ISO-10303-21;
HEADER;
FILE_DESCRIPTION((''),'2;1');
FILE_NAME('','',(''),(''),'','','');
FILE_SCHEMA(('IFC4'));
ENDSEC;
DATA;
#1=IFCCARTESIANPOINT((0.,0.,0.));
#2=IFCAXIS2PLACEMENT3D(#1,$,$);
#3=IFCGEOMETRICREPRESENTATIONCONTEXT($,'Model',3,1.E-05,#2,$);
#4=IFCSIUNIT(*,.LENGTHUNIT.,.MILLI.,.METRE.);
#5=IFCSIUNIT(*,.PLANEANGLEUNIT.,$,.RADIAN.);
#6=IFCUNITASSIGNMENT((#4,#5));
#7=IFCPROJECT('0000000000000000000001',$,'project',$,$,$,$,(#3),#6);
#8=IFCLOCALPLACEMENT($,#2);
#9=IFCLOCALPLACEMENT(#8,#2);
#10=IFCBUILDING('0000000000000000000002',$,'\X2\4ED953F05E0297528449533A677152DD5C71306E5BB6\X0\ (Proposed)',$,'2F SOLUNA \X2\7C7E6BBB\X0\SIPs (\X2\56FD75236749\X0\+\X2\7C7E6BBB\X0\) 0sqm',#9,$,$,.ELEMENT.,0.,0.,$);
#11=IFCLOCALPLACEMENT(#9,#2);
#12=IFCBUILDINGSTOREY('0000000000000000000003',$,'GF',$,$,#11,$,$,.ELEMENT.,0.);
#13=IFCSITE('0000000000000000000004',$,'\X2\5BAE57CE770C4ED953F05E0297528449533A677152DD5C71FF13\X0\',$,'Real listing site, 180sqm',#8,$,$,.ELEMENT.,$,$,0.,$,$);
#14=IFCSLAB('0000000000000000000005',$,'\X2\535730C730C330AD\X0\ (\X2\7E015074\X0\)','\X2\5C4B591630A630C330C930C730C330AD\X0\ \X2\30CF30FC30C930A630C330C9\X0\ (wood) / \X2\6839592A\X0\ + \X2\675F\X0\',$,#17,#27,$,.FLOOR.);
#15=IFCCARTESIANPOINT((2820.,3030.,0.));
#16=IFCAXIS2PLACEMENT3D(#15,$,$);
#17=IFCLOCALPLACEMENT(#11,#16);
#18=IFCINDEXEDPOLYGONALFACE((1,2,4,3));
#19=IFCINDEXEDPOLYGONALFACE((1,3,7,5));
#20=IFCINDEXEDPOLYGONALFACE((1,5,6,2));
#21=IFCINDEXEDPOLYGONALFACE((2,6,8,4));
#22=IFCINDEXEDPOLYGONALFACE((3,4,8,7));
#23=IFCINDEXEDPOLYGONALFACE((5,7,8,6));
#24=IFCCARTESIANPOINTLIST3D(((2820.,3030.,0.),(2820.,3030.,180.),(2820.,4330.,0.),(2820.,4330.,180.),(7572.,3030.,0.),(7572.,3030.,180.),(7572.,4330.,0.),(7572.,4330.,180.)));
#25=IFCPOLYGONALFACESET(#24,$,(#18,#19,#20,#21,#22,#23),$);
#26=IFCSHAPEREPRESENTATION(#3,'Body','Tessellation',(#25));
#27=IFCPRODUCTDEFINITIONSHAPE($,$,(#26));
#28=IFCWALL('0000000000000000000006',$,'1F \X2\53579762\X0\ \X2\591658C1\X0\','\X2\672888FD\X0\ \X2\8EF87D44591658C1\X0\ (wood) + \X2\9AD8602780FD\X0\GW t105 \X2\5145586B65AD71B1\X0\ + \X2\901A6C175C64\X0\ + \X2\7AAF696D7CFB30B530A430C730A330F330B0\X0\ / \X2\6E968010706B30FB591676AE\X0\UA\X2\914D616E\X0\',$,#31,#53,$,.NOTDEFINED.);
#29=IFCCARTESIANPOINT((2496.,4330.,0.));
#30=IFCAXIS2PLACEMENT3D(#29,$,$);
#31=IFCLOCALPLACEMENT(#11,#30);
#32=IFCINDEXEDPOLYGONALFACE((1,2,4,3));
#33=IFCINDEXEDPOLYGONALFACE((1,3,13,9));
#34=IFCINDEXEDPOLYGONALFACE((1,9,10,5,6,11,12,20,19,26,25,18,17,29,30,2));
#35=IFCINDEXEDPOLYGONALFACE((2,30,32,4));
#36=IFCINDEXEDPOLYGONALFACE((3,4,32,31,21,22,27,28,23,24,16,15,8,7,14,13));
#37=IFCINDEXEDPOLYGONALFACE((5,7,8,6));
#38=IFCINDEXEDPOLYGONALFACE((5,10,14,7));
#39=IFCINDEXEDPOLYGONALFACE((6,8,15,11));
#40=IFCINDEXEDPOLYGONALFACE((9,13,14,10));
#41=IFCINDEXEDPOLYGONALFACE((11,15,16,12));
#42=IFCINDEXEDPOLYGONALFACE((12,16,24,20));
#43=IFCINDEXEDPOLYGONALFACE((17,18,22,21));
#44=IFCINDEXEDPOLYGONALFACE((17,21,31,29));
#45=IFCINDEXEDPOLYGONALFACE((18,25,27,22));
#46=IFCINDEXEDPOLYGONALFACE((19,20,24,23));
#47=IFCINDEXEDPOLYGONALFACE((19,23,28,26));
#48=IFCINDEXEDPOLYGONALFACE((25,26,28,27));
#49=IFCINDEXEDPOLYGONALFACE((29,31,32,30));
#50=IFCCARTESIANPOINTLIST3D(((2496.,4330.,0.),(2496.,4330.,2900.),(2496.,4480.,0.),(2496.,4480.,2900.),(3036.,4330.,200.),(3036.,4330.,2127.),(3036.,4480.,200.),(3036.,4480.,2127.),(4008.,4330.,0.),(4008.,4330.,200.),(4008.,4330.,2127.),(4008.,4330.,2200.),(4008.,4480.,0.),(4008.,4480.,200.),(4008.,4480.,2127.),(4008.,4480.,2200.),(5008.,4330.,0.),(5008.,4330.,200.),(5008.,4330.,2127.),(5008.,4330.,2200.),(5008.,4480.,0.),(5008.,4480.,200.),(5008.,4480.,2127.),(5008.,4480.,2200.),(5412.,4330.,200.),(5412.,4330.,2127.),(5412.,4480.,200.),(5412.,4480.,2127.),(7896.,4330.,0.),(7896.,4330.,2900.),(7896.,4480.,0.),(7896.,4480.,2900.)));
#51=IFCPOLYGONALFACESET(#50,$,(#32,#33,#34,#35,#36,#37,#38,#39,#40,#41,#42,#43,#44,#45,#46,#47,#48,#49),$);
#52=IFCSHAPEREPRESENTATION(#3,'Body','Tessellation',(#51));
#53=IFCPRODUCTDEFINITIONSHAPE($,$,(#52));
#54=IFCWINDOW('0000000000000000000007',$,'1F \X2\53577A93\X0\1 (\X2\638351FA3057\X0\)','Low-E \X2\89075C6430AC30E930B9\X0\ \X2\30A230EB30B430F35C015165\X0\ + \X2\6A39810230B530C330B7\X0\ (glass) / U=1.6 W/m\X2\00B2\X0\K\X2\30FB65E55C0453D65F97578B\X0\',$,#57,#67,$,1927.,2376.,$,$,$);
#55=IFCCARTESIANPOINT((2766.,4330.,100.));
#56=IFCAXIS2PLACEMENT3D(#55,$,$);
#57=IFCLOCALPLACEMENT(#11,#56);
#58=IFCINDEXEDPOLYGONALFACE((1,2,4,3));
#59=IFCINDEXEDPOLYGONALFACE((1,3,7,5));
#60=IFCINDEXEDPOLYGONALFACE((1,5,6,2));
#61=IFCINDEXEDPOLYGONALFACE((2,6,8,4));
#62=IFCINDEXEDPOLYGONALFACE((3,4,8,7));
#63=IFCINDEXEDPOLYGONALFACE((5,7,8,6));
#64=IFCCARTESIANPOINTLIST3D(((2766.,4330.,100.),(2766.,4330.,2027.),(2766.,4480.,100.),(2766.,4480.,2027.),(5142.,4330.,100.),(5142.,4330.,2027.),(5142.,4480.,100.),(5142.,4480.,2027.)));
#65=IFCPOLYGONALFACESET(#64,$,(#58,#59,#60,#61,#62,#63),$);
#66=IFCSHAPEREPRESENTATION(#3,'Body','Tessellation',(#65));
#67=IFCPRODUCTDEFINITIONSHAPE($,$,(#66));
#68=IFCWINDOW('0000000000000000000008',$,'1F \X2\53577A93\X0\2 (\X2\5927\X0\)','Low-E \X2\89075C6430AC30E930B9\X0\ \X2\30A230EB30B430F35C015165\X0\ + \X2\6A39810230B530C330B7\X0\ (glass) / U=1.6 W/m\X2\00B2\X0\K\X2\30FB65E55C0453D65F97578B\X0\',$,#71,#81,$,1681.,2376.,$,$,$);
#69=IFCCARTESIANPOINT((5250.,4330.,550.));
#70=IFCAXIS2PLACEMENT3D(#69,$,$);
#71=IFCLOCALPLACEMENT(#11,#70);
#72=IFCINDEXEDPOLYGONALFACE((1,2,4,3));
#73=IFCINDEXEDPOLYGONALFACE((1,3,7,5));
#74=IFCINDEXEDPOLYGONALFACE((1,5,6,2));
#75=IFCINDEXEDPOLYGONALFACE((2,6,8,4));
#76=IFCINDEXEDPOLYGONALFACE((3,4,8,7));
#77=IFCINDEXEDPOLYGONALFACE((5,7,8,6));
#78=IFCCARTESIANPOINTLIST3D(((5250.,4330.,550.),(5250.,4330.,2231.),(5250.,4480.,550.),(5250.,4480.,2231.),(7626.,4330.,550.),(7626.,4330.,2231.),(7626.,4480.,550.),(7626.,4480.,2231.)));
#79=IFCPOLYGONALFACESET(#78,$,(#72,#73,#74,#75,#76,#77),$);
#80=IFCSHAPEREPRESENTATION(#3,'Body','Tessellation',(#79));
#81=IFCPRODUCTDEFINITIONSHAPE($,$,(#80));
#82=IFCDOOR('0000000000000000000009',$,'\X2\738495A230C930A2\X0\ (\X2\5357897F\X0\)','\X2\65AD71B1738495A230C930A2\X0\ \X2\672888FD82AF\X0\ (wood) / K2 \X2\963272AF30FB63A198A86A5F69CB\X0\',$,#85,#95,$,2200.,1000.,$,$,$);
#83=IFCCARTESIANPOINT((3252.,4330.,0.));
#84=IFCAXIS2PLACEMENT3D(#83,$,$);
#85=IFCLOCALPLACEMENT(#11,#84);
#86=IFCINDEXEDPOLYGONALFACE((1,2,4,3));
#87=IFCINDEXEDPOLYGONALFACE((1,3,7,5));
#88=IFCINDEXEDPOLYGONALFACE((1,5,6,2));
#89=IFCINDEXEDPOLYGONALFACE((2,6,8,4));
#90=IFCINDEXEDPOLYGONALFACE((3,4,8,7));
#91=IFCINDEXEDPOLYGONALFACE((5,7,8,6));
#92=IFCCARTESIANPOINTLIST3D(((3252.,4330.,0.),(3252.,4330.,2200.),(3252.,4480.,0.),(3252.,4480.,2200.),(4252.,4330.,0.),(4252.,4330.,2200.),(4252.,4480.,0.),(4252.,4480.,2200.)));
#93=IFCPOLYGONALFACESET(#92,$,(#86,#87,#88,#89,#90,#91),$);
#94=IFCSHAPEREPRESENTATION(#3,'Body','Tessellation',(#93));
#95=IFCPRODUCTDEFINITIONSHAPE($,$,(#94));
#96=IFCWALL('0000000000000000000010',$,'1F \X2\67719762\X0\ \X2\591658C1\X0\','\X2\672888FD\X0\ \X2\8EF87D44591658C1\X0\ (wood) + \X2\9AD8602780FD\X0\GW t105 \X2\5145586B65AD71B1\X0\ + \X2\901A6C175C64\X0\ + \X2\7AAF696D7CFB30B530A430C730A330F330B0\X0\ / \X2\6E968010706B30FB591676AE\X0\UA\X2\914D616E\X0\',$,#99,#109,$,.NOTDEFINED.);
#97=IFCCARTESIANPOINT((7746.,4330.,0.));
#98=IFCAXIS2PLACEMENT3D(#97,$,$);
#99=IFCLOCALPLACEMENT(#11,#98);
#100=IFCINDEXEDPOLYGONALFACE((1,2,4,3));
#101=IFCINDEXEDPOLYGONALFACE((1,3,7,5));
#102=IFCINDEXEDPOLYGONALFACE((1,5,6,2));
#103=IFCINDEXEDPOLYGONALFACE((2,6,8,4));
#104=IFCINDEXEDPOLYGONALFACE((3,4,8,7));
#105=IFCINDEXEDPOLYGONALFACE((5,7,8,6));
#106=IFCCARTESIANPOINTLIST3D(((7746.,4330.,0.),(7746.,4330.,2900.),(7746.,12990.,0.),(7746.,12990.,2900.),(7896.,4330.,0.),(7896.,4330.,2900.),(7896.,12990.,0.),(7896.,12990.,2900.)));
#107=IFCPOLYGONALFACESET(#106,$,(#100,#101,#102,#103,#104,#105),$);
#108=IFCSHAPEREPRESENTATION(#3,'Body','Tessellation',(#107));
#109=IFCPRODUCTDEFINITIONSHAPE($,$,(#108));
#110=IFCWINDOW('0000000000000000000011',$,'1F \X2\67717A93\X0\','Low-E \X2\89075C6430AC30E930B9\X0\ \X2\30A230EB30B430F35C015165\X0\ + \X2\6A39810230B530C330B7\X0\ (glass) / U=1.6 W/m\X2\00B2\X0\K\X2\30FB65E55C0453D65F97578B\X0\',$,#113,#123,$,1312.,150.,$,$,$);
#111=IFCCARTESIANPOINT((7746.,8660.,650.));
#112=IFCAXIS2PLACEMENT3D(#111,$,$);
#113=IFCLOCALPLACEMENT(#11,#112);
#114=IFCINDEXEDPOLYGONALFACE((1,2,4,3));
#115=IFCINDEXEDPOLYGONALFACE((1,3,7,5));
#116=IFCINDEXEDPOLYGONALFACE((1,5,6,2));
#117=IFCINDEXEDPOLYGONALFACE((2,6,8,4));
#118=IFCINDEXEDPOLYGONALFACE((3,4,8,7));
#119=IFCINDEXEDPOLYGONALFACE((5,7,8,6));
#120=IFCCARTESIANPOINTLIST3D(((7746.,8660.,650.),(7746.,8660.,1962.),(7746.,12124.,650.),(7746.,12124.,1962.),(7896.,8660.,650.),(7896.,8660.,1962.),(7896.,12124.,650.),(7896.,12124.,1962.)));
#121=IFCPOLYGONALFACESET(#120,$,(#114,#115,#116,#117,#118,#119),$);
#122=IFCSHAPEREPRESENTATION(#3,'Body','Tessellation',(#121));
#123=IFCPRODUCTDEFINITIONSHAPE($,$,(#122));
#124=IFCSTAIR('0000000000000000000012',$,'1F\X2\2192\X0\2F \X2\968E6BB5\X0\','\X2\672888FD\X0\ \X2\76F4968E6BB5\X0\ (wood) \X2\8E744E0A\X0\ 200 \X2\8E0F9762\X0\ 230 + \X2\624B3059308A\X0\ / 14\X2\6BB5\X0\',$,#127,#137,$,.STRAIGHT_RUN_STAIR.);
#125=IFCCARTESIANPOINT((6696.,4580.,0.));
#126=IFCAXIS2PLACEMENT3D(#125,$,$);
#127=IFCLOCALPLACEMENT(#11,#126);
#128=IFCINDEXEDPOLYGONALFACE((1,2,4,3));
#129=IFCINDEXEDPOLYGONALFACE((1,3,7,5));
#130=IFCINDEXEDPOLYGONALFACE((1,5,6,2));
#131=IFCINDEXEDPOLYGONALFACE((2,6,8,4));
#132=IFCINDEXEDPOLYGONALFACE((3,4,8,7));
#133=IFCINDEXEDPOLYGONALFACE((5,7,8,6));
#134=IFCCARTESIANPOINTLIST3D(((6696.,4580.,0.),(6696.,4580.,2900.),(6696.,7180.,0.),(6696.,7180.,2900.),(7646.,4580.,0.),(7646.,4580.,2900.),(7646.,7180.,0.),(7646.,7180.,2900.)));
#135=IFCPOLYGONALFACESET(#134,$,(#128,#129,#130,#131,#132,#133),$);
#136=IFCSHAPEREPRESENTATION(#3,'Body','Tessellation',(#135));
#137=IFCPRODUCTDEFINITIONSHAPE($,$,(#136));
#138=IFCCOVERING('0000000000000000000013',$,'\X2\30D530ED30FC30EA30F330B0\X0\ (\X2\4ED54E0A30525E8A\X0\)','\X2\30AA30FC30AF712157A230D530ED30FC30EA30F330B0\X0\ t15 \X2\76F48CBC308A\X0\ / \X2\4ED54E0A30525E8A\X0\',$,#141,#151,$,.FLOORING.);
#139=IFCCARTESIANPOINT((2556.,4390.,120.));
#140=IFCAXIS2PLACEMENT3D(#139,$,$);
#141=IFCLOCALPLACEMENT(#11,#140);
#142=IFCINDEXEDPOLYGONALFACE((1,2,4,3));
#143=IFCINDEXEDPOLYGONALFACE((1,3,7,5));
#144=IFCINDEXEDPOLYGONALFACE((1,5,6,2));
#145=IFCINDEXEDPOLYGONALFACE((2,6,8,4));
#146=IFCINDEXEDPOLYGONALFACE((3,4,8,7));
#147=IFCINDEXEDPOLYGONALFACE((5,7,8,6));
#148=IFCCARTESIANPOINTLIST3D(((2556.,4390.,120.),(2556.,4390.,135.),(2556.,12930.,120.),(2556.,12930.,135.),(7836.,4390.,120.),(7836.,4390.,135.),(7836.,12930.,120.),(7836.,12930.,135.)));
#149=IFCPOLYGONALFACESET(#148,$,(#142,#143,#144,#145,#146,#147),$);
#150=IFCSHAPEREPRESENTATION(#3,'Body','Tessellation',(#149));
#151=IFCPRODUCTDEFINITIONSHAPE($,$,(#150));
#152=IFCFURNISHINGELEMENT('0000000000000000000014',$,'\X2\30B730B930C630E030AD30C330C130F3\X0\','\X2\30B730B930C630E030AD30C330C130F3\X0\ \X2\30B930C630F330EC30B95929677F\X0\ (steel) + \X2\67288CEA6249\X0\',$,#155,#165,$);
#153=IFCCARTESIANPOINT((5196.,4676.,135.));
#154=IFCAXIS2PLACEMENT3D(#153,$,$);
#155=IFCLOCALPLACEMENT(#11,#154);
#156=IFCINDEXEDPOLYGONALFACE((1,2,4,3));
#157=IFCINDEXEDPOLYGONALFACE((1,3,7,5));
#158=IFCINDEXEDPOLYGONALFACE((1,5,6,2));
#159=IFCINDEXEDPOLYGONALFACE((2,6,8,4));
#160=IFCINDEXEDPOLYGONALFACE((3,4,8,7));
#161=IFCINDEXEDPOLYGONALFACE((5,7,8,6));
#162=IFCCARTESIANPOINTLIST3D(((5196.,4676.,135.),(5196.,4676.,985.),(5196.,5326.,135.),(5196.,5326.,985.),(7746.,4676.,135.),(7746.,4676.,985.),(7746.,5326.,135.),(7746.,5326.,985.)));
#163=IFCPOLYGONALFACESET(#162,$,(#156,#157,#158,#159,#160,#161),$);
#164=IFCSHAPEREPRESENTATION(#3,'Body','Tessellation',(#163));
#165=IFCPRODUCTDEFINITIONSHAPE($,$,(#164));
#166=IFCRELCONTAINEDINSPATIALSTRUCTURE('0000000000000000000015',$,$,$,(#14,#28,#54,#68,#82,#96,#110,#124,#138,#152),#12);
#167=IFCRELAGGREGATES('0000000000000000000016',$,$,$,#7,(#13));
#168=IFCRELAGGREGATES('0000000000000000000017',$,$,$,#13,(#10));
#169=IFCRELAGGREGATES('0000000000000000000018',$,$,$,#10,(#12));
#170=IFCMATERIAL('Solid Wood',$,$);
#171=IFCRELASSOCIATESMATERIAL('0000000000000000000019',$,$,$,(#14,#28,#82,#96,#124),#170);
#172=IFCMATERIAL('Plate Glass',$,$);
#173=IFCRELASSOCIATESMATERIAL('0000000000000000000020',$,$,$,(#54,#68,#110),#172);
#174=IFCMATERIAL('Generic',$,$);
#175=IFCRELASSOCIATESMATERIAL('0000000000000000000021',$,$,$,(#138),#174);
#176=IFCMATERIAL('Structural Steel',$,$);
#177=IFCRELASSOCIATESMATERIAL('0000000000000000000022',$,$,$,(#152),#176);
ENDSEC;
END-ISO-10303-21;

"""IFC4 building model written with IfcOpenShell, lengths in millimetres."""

from ifc_helpers import new_model, si_unit, frame, frame_2d, origin, place, context, project, spatial, rectangle, extrude, material, element, fill, save


model = new_model("IFC4")

# Units and contexts
model_context = context("Model", 3, precision=1e-05, world=origin())
ifc_project = project(units=[si_unit("LENGTHUNIT", "METRE", prefix="MILLI"), si_unit("PLANEANGLEUNIT", "RADIAN")], contexts=[model_context])

# Site, building, storey
site_placement = place(None, origin())
site = spatial("IfcSite", under=ifc_project, at=site_placement, Name="宮城県仙台市青葉区東勝山３", ObjectType="Real listing site, 180sqm", CompositionType="ELEMENT", RefElevation=0.0)
building_placement = place(site_placement, origin())
building = spatial("IfcBuilding", under=site, at=building_placement, Name="仙台市青葉区東勝山の家 (Proposed)", ObjectType="2F SOLUNA 籾殻SIPs (国産杉+籾殻) 0sqm", CompositionType="ELEMENT", ElevationOfRefHeight=0.0, ElevationOfTerrain=0.0)
storey_placement = place(building_placement, origin())
storey = spatial("IfcBuildingStorey", under=building, at=storey_placement, Name="GF", CompositionType="ELEMENT", Elevation=0.0)

# Slab
ifc_material_1 = material(Name="Solid Wood")
slab_1_placement = place(storey_placement, frame((2820.0, 3030.0, 0.0)))
element("IfcSlab", 1, at=slab_1_placement, inside=storey, material=ifc_material_1, Name="南デッキ (縁側)", Description="屋外ウッドデッキ ハードウッド (wood) / 根太 + 束", PredefinedType="FLOOR", context=model_context, shape_type="SweptSolid", body=[
    extrude(rectangle(XDim=4752.0, YDim=1300.0, at=frame_2d((2376.0, 650.0))), frame((2820.0, 3030.0, 0.0)), (0.0, 0.0, 1.0), 180.0),
])

# Wall, openings, windows, door
wall_1_placement = place(storey_placement, frame((2496.0, 4330.0, 0.0)))
wall_1 = element("IfcWall", 2, at=wall_1_placement, inside=storey, material=ifc_material_1, Name="1F 南面 外壁", Description="木製 軸組外壁 (wood) + 高性能GW t105 充填断熱 + 通気層 + 窯業系サイディング / 準耐火・外皮UA配慮", PredefinedType="NOTDEFINED", context=model_context, shape_type="SweptSolid", body=[
    extrude(rectangle(XDim=5400.0, YDim=150.0, at=frame_2d((2700.0, 75.0))), frame((2496.0, 4330.0, 0.0)), (0.0, 0.0, 1.0), 2900.0),
])
opening_1_placement = place(storey_placement, frame((2766.0, 4330.0, 100.0)))
opening_1 = element("IfcOpeningElement", 3, at=opening_1_placement, cuts=wall_1, PredefinedType="NOTDEFINED", context=model_context, shape_type="SweptSolid", body=[
    extrude(rectangle(XDim=2376.0, YDim=150.0, at=frame_2d((1188.0, 75.0))), frame((2766.0, 4330.0, 100.0)), (0.0, 0.0, 1.0), 1927.0),
])
opening_2_placement = place(storey_placement, frame((5250.0, 4330.0, 550.0)))
opening_2 = element("IfcOpeningElement", 4, at=opening_2_placement, cuts=wall_1, PredefinedType="NOTDEFINED", context=model_context, shape_type="SweptSolid", body=[
    extrude(rectangle(XDim=2376.0, YDim=150.0, at=frame_2d((1188.0, 75.0))), frame((5250.0, 4330.0, 550.0)), (0.0, 0.0, 1.0), 1681.0),
])
opening_3_placement = place(storey_placement, frame((3252.0, 4330.0, 0.0)))
opening_3 = element("IfcOpeningElement", 5, at=opening_3_placement, cuts=wall_1, PredefinedType="NOTDEFINED", context=model_context, shape_type="SweptSolid", body=[
    extrude(rectangle(XDim=1000.0, YDim=150.0, at=frame_2d((500.0, 75.0))), frame((3252.0, 4330.0, 0.0)), (0.0, 0.0, 1.0), 2200.0),
])
ifc_material_2 = material(Name="Plate Glass")
window_1_placement = place(storey_placement, frame((2766.0, 4330.0, 100.0)))
window_1 = element("IfcWindow", 6, at=window_1_placement, inside=storey, material=ifc_material_2, Name="1F 南窓1 (掃出し)", Description="Low-E 複層ガラス アルゴン封入 + 樹脂サッシ (glass) / U=1.6 W/m²K・日射取得型", OverallHeight=1927.0, OverallWidth=2376.0, context=model_context, shape_type="SweptSolid", body=[
    extrude(rectangle(XDim=2376.0, YDim=150.0, at=frame_2d((1188.0, 75.0))), frame((2766.0, 4330.0, 100.0)), (0.0, 0.0, 1.0), 1927.0),
])
fill(opening_1, window_1)
window_2_placement = place(storey_placement, frame((5250.0, 4330.0, 550.0)))
window_2 = element("IfcWindow", 7, at=window_2_placement, inside=storey, material=ifc_material_2, Name="1F 南窓2 (大)", Description="Low-E 複層ガラス アルゴン封入 + 樹脂サッシ (glass) / U=1.6 W/m²K・日射取得型", OverallHeight=1681.0, OverallWidth=2376.0, context=model_context, shape_type="SweptSolid", body=[
    extrude(rectangle(XDim=2376.0, YDim=150.0, at=frame_2d((1188.0, 75.0))), frame((5250.0, 4330.0, 550.0)), (0.0, 0.0, 1.0), 1681.0),
])
fill(opening_2, window_2)
door_placement = place(storey_placement, frame((3252.0, 4330.0, 0.0)))
door = element("IfcDoor", 8, at=door_placement, inside=storey, material=ifc_material_1, Name="玄関ドア (南西)", Description="断熱玄関ドア 木製芯 (wood) / K2 防犯・採風機構", OverallHeight=2200.0, OverallWidth=1000.0, context=model_context, shape_type="SweptSolid", body=[
    extrude(rectangle(XDim=1000.0, YDim=150.0, at=frame_2d((500.0, 75.0))), frame((3252.0, 4330.0, 0.0)), (0.0, 0.0, 1.0), 2200.0),
])
fill(opening_3, door)

# Wall, opening, window
wall_2_placement = place(storey_placement, frame((7746.0, 4330.0, 0.0)))
wall_2 = element("IfcWall", 9, at=wall_2_placement, inside=storey, material=ifc_material_1, Name="1F 東面 外壁", Description="木製 軸組外壁 (wood) + 高性能GW t105 充填断熱 + 通気層 + 窯業系サイディング / 準耐火・外皮UA配慮", PredefinedType="NOTDEFINED", context=model_context, shape_type="SweptSolid", body=[
    extrude(rectangle(XDim=150.0, YDim=8660.0, at=frame_2d((75.0, 4330.0))), frame((7746.0, 4330.0, 0.0)), (0.0, 0.0, 1.0), 2900.0),
])
opening_4_placement = place(storey_placement, frame((7746.0, 8660.0, 650.0)))
opening_4 = element("IfcOpeningElement", 10, at=opening_4_placement, cuts=wall_2, PredefinedType="NOTDEFINED", context=model_context, shape_type="SweptSolid", body=[
    extrude(rectangle(XDim=150.0, YDim=3464.0, at=frame_2d((75.0, 1732.0))), frame((7746.0, 8660.0, 650.0)), (0.0, 0.0, 1.0), 1312.0),
])
window_3_placement = place(storey_placement, frame((7746.0, 8660.0, 650.0)))
window_3 = element("IfcWindow", 11, at=window_3_placement, inside=storey, material=ifc_material_2, Name="1F 東窓", Description="Low-E 複層ガラス アルゴン封入 + 樹脂サッシ (glass) / U=1.6 W/m²K・日射取得型", OverallHeight=1312.0, OverallWidth=150.0, context=model_context, shape_type="SweptSolid", body=[
    extrude(rectangle(XDim=150.0, YDim=3464.0, at=frame_2d((75.0, 1732.0))), frame((7746.0, 8660.0, 650.0)), (0.0, 0.0, 1.0), 1312.0),
])
fill(opening_4, window_3)

# Stair
stair_placement = place(storey_placement, frame((6696.0, 4580.0, 0.0)))
element("IfcStair", 12, at=stair_placement, inside=storey, material=ifc_material_1, Name="1F→2F 階段", Description="木製 直階段 (wood) 蹴上 200 踏面 230 + 手すり / 14段", PredefinedType="STRAIGHT_RUN_STAIR", context=model_context, shape_type="SweptSolid", body=[
    extrude(rectangle(XDim=950.0, YDim=2600.0, at=frame_2d((475.0, 1300.0))), frame((6696.0, 4580.0, 0.0)), (0.0, 0.0, 1.0), 2900.0),
])

# Covering
ifc_material_3 = material(Name="Generic")
covering_placement = place(storey_placement, frame((2556.0, 4390.0, 120.0)))
element("IfcCovering", 13, at=covering_placement, inside=storey, material=ifc_material_3, Name="フローリング (仕上げ床)", Description="オーク無垢フローリング t15 直貼り / 仕上げ床", PredefinedType="FLOORING", context=model_context, shape_type="SweptSolid", body=[
    extrude(rectangle(XDim=5280.0, YDim=8540.0, at=frame_2d((2640.0, 4270.0))), frame((2556.0, 4390.0, 120.0)), (0.0, 0.0, 1.0), 15.0),
])

# Furnishing element
ifc_material_4 = material(Name="Structural Steel")
furnishing_placement = place(storey_placement, frame((5196.0, 4676.0, 135.0)))
element("IfcFurnishingElement", 14, at=furnishing_placement, inside=storey, material=ifc_material_4, Name="システムキッチン", Description="システムキッチン ステンレス天板 (steel) + 木質扉", context=model_context, shape_type="SweptSolid", body=[
    extrude(rectangle(XDim=2550.0, YDim=650.0, at=frame_2d((1275.0, 325.0))), frame((5196.0, 4676.0, 135.0)), (0.0, 0.0, 1.0), 850.0),
])

save(model, "model.ifc")
